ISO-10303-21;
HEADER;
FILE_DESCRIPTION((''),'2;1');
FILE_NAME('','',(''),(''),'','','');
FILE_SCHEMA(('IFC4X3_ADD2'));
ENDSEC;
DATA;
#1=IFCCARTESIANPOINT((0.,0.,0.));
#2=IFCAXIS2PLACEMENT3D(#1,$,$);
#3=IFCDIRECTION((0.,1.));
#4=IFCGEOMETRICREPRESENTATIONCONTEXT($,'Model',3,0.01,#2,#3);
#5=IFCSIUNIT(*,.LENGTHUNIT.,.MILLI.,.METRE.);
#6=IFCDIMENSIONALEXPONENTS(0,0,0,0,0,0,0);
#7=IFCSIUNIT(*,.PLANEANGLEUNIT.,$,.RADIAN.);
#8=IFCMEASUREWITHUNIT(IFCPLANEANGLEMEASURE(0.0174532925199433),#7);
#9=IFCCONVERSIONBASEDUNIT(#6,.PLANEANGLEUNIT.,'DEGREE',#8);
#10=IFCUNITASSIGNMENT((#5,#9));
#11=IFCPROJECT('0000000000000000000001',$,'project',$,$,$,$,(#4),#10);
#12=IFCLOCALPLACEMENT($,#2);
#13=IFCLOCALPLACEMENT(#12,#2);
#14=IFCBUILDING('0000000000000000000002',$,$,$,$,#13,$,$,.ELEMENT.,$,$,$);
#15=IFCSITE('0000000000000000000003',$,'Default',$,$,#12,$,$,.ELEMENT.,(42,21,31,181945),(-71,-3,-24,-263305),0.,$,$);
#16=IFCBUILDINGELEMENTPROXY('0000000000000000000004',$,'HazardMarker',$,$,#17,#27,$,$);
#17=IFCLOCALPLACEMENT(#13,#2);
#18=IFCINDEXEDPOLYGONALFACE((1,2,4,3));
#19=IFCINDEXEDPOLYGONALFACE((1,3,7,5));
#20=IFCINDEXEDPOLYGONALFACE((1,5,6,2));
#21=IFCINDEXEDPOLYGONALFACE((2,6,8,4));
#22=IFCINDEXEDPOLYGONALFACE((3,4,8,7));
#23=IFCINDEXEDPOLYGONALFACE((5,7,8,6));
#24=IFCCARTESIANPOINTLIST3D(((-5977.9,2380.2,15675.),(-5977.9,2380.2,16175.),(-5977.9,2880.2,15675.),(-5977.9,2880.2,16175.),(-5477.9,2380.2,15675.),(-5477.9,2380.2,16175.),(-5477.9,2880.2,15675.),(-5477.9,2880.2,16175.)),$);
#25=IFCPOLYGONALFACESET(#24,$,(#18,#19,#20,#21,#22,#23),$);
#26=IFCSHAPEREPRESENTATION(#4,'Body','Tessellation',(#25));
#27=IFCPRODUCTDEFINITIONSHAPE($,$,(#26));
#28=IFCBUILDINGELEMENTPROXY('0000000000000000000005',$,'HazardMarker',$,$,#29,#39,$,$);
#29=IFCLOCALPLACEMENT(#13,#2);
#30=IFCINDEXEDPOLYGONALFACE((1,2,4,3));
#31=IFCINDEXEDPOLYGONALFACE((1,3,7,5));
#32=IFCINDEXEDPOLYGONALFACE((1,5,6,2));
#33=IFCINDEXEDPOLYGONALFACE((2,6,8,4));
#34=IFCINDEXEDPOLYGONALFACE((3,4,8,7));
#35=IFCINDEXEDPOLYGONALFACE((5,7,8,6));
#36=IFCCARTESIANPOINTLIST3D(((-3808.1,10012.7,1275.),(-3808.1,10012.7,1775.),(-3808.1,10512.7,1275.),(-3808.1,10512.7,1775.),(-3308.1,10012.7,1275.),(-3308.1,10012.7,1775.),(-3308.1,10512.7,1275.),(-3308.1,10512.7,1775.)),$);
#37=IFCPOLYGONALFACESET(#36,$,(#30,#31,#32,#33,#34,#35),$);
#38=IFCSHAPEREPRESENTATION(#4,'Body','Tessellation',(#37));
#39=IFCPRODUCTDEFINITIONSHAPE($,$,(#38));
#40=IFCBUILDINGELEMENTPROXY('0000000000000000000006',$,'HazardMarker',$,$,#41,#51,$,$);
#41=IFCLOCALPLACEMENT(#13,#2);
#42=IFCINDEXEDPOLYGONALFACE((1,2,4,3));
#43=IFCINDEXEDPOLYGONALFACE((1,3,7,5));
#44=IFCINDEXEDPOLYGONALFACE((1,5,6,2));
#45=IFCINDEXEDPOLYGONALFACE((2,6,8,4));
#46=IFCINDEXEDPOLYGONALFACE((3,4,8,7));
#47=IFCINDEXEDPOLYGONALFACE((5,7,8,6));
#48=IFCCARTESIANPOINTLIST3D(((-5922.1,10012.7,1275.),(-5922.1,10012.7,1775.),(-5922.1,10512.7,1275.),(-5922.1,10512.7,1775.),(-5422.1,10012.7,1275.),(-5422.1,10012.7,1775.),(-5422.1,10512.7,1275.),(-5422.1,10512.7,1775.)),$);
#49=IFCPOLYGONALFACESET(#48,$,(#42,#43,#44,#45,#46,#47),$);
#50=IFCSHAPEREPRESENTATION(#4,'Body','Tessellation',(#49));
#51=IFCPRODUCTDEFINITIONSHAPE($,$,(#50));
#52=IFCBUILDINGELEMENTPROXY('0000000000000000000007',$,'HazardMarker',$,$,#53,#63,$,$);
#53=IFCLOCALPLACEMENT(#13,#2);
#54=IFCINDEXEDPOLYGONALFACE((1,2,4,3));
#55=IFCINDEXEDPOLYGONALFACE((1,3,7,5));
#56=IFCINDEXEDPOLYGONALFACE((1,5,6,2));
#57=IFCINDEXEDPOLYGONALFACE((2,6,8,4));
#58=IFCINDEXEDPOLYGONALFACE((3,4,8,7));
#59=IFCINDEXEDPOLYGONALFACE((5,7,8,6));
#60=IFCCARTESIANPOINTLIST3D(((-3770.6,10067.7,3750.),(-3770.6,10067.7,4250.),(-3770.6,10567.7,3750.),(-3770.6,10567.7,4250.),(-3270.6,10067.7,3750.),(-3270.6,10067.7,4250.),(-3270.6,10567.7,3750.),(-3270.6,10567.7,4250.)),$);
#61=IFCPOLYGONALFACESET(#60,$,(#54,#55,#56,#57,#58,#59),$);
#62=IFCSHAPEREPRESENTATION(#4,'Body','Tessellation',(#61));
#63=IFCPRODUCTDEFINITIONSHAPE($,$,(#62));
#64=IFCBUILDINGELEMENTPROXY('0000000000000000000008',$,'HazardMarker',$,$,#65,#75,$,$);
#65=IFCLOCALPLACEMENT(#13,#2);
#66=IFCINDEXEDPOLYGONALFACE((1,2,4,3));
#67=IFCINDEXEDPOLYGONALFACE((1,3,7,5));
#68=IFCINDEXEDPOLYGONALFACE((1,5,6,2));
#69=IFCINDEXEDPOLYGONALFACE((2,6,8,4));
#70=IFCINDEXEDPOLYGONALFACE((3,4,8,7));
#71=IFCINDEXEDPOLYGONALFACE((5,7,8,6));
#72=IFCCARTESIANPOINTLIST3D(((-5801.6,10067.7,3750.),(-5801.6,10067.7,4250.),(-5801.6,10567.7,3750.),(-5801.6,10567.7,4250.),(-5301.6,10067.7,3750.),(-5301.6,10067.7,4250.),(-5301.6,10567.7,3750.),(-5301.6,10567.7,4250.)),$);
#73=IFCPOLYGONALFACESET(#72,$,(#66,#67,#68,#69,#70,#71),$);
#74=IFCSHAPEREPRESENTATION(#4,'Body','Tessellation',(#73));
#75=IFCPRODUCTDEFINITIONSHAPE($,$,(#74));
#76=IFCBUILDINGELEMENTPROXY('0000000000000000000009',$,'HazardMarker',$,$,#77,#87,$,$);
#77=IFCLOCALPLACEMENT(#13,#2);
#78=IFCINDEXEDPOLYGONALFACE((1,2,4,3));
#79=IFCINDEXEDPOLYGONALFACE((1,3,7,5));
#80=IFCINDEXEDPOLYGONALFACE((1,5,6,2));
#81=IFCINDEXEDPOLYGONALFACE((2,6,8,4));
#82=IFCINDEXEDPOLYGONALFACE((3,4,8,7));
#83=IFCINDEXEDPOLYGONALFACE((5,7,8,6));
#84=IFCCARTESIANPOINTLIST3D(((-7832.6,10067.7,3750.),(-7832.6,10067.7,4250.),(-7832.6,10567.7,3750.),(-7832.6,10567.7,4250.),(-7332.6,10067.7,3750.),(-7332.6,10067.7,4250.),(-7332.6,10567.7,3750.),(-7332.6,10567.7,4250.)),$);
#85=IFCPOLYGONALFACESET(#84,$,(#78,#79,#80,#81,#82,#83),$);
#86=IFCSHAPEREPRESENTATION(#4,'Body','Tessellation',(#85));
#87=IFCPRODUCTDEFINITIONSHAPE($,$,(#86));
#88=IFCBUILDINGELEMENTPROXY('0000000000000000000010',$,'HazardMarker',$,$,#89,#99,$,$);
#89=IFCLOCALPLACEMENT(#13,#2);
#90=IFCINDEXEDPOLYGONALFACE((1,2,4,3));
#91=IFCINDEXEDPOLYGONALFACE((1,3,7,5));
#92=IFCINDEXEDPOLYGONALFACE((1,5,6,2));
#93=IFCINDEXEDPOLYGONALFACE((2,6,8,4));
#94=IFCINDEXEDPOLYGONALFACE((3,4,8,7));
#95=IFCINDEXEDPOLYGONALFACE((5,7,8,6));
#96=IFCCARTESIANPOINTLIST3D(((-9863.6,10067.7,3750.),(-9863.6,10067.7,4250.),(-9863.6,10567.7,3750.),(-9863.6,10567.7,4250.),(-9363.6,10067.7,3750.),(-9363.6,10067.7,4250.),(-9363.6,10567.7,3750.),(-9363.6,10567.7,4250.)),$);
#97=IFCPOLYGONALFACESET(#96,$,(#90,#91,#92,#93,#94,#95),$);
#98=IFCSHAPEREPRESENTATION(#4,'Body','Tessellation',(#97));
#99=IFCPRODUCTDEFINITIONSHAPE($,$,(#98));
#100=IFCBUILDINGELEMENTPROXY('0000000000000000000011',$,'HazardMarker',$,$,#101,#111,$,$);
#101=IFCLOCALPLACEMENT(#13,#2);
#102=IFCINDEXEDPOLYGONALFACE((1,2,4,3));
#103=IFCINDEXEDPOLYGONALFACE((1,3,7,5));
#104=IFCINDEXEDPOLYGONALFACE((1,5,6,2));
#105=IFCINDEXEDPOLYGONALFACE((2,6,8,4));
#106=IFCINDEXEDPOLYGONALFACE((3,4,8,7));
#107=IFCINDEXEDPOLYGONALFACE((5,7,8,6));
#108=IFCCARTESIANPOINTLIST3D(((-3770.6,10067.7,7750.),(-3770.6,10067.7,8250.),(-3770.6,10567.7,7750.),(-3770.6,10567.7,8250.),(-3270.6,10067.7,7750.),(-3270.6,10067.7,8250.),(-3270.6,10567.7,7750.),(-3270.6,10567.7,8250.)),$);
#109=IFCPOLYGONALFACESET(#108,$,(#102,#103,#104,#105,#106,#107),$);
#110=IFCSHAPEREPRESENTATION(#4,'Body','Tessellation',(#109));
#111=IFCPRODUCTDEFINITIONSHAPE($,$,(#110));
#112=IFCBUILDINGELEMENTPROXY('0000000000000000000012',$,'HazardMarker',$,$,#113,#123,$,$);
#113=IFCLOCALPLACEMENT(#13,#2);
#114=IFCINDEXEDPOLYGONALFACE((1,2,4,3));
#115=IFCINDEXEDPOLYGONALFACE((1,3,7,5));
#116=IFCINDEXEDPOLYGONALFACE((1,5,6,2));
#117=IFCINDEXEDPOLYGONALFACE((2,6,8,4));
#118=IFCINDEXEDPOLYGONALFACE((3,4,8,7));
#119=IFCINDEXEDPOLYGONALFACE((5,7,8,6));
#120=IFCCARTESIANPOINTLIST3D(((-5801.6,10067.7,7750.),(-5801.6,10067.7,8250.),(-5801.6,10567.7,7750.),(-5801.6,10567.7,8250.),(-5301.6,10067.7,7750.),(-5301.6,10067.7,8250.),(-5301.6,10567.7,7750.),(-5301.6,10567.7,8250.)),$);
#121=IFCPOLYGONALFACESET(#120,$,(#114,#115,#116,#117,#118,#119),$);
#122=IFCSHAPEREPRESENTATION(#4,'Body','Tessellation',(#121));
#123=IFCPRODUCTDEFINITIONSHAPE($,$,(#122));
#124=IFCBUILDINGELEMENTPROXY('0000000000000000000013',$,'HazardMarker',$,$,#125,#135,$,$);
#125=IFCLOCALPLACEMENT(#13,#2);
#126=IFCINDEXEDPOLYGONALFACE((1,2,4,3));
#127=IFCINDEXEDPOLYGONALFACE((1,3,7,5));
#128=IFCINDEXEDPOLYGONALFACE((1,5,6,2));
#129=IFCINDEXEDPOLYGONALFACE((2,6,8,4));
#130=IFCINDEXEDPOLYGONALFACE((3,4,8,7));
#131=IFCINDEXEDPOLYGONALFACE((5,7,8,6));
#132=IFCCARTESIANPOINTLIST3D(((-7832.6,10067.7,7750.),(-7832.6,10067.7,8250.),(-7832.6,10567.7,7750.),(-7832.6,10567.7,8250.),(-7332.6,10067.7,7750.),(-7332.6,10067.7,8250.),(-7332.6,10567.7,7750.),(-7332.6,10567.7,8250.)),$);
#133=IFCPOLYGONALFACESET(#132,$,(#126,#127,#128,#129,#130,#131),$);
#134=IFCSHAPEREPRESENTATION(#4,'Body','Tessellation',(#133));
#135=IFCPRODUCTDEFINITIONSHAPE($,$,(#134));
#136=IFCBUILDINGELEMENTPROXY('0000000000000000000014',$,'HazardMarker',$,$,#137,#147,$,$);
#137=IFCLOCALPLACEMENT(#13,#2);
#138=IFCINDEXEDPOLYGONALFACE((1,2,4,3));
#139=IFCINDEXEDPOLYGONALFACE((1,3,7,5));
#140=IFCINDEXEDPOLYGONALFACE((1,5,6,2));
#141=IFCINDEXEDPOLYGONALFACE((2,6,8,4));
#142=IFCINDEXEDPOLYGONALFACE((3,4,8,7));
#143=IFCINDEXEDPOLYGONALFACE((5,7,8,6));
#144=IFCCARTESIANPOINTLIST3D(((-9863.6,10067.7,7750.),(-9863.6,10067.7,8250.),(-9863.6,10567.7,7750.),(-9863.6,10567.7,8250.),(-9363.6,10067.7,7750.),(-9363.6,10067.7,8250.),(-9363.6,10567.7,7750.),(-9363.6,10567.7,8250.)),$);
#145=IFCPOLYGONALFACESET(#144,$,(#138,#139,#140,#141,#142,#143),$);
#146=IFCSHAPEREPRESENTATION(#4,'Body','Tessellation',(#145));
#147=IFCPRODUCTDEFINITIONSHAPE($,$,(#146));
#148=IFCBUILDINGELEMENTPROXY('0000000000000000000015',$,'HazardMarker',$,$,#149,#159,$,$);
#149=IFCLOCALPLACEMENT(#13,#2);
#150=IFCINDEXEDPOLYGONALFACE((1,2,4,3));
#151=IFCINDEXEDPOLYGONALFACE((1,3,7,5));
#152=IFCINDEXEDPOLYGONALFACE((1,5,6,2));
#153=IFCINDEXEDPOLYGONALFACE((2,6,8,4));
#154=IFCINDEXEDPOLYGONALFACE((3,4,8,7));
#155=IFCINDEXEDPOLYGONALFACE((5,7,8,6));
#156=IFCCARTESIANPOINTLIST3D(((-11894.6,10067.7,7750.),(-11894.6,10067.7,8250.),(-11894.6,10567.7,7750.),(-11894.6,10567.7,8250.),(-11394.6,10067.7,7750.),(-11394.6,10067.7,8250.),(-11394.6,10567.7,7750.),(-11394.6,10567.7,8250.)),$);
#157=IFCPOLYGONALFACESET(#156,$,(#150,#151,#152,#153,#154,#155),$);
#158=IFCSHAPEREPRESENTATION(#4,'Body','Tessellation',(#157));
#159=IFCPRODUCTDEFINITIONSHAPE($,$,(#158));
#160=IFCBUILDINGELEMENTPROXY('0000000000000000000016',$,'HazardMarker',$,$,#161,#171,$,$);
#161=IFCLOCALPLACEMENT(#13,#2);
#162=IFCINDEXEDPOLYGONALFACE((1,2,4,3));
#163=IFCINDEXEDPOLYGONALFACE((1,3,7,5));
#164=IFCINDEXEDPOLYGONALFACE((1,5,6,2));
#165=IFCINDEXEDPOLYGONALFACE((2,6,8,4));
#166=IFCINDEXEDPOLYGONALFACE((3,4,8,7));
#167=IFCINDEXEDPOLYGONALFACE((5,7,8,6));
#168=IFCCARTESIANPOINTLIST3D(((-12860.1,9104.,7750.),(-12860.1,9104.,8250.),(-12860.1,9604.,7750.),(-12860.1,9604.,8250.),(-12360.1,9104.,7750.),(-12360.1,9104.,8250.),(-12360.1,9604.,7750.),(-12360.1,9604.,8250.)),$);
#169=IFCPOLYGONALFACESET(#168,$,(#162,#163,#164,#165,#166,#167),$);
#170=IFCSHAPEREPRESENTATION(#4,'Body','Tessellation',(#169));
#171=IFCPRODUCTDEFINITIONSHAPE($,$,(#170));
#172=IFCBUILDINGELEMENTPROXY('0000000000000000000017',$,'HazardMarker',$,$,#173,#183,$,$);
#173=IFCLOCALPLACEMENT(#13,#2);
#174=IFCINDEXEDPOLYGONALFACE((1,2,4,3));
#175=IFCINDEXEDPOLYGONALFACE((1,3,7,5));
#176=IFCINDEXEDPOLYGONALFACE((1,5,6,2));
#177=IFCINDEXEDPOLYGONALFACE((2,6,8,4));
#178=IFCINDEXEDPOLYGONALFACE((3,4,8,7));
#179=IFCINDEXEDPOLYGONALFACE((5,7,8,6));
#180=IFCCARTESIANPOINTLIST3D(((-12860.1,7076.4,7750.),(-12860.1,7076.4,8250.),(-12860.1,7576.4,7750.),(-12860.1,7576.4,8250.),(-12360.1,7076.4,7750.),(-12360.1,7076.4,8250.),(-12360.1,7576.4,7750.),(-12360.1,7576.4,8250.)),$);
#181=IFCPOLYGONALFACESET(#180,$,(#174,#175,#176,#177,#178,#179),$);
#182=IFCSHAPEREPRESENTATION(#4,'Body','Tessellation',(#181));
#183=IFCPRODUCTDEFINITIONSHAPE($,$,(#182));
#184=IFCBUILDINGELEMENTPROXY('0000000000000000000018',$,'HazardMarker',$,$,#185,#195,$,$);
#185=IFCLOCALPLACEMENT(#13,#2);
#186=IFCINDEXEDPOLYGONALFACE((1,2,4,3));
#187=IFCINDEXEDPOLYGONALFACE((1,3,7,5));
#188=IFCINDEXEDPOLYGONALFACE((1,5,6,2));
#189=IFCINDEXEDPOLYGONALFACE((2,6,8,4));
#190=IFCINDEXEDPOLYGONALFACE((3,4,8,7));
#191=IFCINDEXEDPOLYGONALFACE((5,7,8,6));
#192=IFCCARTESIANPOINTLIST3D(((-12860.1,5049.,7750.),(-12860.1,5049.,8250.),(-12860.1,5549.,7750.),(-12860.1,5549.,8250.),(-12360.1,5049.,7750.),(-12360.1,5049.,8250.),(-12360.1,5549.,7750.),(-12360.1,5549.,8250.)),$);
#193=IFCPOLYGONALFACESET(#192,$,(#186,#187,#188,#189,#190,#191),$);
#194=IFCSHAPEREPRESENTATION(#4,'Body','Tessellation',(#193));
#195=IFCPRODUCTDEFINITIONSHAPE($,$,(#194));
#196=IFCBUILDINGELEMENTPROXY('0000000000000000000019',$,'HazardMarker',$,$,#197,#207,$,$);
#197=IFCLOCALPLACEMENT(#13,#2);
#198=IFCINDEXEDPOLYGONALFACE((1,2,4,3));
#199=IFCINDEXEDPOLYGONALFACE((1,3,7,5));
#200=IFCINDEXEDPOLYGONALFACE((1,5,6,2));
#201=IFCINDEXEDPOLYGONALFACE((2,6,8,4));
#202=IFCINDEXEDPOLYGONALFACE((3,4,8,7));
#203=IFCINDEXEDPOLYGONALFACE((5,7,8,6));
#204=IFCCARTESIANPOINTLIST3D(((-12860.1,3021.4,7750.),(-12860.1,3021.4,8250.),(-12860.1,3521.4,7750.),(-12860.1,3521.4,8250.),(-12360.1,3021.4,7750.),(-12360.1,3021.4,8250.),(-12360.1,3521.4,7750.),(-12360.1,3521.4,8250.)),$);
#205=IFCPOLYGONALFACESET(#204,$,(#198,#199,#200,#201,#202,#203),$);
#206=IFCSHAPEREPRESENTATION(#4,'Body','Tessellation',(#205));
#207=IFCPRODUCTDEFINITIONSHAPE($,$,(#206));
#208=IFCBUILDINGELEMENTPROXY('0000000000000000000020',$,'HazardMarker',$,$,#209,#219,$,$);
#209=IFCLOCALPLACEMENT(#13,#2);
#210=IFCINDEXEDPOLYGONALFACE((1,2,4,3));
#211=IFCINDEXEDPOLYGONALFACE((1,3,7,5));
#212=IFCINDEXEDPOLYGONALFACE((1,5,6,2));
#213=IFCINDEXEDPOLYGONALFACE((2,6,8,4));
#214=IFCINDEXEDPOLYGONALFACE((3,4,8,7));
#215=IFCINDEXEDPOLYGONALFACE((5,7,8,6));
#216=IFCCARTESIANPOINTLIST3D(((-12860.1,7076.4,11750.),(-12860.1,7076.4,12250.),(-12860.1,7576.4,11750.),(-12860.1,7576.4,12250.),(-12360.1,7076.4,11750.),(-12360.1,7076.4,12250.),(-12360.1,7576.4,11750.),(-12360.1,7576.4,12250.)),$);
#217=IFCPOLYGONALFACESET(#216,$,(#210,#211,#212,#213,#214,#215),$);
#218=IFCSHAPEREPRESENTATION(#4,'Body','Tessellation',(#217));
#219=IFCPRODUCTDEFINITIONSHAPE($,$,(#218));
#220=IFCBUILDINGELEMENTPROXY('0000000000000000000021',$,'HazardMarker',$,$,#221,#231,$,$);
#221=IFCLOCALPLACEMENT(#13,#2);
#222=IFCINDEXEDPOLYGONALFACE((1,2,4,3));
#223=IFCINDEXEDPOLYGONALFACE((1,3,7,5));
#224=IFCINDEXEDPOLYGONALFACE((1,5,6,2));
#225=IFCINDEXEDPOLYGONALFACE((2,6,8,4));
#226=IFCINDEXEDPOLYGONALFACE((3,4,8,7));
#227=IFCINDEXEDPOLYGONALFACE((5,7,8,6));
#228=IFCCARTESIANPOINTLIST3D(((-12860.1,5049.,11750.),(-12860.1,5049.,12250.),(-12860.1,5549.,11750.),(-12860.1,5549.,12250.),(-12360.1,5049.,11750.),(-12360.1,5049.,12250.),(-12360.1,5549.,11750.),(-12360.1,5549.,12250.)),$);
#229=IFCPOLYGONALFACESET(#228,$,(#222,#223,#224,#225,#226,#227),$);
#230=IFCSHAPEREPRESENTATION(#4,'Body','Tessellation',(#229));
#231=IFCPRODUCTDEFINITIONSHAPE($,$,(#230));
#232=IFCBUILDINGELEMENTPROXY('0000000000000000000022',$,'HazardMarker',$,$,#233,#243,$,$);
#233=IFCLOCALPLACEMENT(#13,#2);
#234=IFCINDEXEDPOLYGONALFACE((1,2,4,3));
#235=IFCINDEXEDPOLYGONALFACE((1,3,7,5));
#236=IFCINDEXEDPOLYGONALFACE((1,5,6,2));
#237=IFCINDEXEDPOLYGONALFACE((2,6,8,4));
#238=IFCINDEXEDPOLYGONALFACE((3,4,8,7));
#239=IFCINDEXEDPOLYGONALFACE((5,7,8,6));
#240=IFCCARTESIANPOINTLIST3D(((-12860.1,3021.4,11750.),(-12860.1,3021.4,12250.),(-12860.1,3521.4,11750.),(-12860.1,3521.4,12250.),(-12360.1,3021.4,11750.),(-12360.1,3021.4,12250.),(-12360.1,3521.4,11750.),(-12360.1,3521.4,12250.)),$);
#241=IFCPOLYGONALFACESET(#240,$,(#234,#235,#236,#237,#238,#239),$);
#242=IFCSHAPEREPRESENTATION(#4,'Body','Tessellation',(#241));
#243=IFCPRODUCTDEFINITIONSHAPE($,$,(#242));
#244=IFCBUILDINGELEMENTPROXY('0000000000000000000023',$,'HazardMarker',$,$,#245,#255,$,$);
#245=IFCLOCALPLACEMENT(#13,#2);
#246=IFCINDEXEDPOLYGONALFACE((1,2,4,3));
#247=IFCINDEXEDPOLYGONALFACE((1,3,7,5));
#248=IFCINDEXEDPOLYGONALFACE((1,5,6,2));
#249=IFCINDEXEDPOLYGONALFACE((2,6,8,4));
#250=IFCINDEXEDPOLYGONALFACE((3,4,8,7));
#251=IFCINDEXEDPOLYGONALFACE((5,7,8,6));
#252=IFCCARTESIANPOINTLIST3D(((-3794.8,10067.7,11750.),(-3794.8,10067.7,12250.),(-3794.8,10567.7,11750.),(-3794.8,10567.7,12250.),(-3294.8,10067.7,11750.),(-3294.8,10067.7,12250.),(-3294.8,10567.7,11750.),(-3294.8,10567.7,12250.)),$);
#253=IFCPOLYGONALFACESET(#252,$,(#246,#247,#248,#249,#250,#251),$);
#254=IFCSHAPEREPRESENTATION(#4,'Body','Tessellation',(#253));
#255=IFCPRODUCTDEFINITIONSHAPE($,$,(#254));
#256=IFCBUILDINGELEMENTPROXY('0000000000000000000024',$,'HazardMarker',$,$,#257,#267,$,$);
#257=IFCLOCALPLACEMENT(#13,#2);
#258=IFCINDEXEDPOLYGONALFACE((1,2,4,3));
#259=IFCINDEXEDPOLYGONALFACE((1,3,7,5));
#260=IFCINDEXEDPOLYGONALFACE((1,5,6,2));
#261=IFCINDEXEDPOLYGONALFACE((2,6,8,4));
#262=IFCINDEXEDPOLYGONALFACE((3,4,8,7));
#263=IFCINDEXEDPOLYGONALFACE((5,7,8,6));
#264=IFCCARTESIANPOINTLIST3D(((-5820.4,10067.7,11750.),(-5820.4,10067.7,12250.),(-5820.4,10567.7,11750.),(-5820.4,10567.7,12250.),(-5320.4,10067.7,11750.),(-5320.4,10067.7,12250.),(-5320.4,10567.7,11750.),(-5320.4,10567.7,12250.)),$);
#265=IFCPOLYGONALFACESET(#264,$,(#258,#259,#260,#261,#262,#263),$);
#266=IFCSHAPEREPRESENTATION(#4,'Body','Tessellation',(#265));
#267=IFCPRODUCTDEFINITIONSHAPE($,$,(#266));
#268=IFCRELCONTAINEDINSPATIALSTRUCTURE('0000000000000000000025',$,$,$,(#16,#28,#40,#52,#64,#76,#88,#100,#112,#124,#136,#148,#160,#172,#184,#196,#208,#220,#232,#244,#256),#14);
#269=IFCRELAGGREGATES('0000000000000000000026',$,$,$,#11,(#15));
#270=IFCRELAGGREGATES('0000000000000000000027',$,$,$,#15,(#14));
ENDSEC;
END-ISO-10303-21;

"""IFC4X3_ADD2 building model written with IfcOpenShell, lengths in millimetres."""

from ifc_helpers import new_model, entity, si_unit, converted_unit, direction, frame, origin, place, context, project, spatial, rectangle, extrude, element, save


model = new_model("IFC4X3_ADD2")

# Units and contexts
model_context = context("Model", 3, precision=0.01, world=origin(), true_north=direction((0.0, 1.0)))
ifc_project = project(units=[si_unit("LENGTHUNIT", "METRE", prefix="MILLI"), converted_unit("PLANEANGLEUNIT", "DEGREE", entity("IfcPlaneAngleMeasure", 0.0174532925199433), si_unit("PLANEANGLEUNIT", "RADIAN"), dimensions=[0, 0, 0, 0, 0, 0, 0])], contexts=[model_context])

# Site, building
site_placement = place(None, origin())
site = spatial("IfcSite", under=ifc_project, at=site_placement, Name="Default", CompositionType="ELEMENT", RefLatitude=(42, 21, 31, 181945), RefLongitude=(-71, -3, -24, -263305), RefElevation=0.0)
building_placement = place(site_placement, origin())
building = spatial("IfcBuilding", under=site, at=building_placement, CompositionType="ELEMENT")

# Building element proxies
for number, where, name in (
    (1, (-5727.9, 2630.2, 15925.0), "HazardMarker"),
    (2, (-3558.1, 10262.7, 1525.0), "HazardMarker"),
    (3, (-5672.1, 10262.7, 1525.0), "HazardMarker"),
    (4, (-3520.6, 10317.7, 4000.0), "HazardMarker"),
    (5, (-5551.6, 10317.7, 4000.0), "HazardMarker"),
    (6, (-7582.6, 10317.7, 4000.0), "HazardMarker"),
    (7, (-9613.6, 10317.7, 4000.0), "HazardMarker"),
    (8, (-3520.6, 10317.7, 8000.0), "HazardMarker"),
    (9, (-5551.6, 10317.7, 8000.0), "HazardMarker"),
    (10, (-7582.6, 10317.7, 8000.0), "HazardMarker"),
    (11, (-9613.6, 10317.7, 8000.0), "HazardMarker"),
    (12, (-11644.6, 10317.7, 8000.0), "HazardMarker"),
    (13, (-12610.1, 9354.0, 8000.0), "HazardMarker"),
    (14, (-12610.1, 7326.4, 8000.0), "HazardMarker"),
    (15, (-12610.1, 5298.9, 8000.0), "HazardMarker"),
    (16, (-12610.1, 3271.4, 8000.0), "HazardMarker"),
    (17, (-12610.1, 7326.4, 12000.0), "HazardMarker"),
    (18, (-12610.1, 5298.9, 12000.0), "HazardMarker"),
    (19, (-12610.1, 3271.4, 12000.0), "HazardMarker"),
    (20, (-3544.8, 10317.7, 12000.0), "HazardMarker"),
    (21, (-5570.4, 10317.7, 12000.0), "HazardMarker"),
):
    element("IfcBuildingElementProxy", number, at=place(None, frame(where)), inside=building, Name=name, context=model_context, shape_type="SweptSolid", body=[
        extrude(rectangle(XDim=500.0, YDim=500.0), frame((0.0, 0.0, -250.0)), (0.0, 0.0, 1.0), 500.0),
    ])

save(model, "model.ifc")
